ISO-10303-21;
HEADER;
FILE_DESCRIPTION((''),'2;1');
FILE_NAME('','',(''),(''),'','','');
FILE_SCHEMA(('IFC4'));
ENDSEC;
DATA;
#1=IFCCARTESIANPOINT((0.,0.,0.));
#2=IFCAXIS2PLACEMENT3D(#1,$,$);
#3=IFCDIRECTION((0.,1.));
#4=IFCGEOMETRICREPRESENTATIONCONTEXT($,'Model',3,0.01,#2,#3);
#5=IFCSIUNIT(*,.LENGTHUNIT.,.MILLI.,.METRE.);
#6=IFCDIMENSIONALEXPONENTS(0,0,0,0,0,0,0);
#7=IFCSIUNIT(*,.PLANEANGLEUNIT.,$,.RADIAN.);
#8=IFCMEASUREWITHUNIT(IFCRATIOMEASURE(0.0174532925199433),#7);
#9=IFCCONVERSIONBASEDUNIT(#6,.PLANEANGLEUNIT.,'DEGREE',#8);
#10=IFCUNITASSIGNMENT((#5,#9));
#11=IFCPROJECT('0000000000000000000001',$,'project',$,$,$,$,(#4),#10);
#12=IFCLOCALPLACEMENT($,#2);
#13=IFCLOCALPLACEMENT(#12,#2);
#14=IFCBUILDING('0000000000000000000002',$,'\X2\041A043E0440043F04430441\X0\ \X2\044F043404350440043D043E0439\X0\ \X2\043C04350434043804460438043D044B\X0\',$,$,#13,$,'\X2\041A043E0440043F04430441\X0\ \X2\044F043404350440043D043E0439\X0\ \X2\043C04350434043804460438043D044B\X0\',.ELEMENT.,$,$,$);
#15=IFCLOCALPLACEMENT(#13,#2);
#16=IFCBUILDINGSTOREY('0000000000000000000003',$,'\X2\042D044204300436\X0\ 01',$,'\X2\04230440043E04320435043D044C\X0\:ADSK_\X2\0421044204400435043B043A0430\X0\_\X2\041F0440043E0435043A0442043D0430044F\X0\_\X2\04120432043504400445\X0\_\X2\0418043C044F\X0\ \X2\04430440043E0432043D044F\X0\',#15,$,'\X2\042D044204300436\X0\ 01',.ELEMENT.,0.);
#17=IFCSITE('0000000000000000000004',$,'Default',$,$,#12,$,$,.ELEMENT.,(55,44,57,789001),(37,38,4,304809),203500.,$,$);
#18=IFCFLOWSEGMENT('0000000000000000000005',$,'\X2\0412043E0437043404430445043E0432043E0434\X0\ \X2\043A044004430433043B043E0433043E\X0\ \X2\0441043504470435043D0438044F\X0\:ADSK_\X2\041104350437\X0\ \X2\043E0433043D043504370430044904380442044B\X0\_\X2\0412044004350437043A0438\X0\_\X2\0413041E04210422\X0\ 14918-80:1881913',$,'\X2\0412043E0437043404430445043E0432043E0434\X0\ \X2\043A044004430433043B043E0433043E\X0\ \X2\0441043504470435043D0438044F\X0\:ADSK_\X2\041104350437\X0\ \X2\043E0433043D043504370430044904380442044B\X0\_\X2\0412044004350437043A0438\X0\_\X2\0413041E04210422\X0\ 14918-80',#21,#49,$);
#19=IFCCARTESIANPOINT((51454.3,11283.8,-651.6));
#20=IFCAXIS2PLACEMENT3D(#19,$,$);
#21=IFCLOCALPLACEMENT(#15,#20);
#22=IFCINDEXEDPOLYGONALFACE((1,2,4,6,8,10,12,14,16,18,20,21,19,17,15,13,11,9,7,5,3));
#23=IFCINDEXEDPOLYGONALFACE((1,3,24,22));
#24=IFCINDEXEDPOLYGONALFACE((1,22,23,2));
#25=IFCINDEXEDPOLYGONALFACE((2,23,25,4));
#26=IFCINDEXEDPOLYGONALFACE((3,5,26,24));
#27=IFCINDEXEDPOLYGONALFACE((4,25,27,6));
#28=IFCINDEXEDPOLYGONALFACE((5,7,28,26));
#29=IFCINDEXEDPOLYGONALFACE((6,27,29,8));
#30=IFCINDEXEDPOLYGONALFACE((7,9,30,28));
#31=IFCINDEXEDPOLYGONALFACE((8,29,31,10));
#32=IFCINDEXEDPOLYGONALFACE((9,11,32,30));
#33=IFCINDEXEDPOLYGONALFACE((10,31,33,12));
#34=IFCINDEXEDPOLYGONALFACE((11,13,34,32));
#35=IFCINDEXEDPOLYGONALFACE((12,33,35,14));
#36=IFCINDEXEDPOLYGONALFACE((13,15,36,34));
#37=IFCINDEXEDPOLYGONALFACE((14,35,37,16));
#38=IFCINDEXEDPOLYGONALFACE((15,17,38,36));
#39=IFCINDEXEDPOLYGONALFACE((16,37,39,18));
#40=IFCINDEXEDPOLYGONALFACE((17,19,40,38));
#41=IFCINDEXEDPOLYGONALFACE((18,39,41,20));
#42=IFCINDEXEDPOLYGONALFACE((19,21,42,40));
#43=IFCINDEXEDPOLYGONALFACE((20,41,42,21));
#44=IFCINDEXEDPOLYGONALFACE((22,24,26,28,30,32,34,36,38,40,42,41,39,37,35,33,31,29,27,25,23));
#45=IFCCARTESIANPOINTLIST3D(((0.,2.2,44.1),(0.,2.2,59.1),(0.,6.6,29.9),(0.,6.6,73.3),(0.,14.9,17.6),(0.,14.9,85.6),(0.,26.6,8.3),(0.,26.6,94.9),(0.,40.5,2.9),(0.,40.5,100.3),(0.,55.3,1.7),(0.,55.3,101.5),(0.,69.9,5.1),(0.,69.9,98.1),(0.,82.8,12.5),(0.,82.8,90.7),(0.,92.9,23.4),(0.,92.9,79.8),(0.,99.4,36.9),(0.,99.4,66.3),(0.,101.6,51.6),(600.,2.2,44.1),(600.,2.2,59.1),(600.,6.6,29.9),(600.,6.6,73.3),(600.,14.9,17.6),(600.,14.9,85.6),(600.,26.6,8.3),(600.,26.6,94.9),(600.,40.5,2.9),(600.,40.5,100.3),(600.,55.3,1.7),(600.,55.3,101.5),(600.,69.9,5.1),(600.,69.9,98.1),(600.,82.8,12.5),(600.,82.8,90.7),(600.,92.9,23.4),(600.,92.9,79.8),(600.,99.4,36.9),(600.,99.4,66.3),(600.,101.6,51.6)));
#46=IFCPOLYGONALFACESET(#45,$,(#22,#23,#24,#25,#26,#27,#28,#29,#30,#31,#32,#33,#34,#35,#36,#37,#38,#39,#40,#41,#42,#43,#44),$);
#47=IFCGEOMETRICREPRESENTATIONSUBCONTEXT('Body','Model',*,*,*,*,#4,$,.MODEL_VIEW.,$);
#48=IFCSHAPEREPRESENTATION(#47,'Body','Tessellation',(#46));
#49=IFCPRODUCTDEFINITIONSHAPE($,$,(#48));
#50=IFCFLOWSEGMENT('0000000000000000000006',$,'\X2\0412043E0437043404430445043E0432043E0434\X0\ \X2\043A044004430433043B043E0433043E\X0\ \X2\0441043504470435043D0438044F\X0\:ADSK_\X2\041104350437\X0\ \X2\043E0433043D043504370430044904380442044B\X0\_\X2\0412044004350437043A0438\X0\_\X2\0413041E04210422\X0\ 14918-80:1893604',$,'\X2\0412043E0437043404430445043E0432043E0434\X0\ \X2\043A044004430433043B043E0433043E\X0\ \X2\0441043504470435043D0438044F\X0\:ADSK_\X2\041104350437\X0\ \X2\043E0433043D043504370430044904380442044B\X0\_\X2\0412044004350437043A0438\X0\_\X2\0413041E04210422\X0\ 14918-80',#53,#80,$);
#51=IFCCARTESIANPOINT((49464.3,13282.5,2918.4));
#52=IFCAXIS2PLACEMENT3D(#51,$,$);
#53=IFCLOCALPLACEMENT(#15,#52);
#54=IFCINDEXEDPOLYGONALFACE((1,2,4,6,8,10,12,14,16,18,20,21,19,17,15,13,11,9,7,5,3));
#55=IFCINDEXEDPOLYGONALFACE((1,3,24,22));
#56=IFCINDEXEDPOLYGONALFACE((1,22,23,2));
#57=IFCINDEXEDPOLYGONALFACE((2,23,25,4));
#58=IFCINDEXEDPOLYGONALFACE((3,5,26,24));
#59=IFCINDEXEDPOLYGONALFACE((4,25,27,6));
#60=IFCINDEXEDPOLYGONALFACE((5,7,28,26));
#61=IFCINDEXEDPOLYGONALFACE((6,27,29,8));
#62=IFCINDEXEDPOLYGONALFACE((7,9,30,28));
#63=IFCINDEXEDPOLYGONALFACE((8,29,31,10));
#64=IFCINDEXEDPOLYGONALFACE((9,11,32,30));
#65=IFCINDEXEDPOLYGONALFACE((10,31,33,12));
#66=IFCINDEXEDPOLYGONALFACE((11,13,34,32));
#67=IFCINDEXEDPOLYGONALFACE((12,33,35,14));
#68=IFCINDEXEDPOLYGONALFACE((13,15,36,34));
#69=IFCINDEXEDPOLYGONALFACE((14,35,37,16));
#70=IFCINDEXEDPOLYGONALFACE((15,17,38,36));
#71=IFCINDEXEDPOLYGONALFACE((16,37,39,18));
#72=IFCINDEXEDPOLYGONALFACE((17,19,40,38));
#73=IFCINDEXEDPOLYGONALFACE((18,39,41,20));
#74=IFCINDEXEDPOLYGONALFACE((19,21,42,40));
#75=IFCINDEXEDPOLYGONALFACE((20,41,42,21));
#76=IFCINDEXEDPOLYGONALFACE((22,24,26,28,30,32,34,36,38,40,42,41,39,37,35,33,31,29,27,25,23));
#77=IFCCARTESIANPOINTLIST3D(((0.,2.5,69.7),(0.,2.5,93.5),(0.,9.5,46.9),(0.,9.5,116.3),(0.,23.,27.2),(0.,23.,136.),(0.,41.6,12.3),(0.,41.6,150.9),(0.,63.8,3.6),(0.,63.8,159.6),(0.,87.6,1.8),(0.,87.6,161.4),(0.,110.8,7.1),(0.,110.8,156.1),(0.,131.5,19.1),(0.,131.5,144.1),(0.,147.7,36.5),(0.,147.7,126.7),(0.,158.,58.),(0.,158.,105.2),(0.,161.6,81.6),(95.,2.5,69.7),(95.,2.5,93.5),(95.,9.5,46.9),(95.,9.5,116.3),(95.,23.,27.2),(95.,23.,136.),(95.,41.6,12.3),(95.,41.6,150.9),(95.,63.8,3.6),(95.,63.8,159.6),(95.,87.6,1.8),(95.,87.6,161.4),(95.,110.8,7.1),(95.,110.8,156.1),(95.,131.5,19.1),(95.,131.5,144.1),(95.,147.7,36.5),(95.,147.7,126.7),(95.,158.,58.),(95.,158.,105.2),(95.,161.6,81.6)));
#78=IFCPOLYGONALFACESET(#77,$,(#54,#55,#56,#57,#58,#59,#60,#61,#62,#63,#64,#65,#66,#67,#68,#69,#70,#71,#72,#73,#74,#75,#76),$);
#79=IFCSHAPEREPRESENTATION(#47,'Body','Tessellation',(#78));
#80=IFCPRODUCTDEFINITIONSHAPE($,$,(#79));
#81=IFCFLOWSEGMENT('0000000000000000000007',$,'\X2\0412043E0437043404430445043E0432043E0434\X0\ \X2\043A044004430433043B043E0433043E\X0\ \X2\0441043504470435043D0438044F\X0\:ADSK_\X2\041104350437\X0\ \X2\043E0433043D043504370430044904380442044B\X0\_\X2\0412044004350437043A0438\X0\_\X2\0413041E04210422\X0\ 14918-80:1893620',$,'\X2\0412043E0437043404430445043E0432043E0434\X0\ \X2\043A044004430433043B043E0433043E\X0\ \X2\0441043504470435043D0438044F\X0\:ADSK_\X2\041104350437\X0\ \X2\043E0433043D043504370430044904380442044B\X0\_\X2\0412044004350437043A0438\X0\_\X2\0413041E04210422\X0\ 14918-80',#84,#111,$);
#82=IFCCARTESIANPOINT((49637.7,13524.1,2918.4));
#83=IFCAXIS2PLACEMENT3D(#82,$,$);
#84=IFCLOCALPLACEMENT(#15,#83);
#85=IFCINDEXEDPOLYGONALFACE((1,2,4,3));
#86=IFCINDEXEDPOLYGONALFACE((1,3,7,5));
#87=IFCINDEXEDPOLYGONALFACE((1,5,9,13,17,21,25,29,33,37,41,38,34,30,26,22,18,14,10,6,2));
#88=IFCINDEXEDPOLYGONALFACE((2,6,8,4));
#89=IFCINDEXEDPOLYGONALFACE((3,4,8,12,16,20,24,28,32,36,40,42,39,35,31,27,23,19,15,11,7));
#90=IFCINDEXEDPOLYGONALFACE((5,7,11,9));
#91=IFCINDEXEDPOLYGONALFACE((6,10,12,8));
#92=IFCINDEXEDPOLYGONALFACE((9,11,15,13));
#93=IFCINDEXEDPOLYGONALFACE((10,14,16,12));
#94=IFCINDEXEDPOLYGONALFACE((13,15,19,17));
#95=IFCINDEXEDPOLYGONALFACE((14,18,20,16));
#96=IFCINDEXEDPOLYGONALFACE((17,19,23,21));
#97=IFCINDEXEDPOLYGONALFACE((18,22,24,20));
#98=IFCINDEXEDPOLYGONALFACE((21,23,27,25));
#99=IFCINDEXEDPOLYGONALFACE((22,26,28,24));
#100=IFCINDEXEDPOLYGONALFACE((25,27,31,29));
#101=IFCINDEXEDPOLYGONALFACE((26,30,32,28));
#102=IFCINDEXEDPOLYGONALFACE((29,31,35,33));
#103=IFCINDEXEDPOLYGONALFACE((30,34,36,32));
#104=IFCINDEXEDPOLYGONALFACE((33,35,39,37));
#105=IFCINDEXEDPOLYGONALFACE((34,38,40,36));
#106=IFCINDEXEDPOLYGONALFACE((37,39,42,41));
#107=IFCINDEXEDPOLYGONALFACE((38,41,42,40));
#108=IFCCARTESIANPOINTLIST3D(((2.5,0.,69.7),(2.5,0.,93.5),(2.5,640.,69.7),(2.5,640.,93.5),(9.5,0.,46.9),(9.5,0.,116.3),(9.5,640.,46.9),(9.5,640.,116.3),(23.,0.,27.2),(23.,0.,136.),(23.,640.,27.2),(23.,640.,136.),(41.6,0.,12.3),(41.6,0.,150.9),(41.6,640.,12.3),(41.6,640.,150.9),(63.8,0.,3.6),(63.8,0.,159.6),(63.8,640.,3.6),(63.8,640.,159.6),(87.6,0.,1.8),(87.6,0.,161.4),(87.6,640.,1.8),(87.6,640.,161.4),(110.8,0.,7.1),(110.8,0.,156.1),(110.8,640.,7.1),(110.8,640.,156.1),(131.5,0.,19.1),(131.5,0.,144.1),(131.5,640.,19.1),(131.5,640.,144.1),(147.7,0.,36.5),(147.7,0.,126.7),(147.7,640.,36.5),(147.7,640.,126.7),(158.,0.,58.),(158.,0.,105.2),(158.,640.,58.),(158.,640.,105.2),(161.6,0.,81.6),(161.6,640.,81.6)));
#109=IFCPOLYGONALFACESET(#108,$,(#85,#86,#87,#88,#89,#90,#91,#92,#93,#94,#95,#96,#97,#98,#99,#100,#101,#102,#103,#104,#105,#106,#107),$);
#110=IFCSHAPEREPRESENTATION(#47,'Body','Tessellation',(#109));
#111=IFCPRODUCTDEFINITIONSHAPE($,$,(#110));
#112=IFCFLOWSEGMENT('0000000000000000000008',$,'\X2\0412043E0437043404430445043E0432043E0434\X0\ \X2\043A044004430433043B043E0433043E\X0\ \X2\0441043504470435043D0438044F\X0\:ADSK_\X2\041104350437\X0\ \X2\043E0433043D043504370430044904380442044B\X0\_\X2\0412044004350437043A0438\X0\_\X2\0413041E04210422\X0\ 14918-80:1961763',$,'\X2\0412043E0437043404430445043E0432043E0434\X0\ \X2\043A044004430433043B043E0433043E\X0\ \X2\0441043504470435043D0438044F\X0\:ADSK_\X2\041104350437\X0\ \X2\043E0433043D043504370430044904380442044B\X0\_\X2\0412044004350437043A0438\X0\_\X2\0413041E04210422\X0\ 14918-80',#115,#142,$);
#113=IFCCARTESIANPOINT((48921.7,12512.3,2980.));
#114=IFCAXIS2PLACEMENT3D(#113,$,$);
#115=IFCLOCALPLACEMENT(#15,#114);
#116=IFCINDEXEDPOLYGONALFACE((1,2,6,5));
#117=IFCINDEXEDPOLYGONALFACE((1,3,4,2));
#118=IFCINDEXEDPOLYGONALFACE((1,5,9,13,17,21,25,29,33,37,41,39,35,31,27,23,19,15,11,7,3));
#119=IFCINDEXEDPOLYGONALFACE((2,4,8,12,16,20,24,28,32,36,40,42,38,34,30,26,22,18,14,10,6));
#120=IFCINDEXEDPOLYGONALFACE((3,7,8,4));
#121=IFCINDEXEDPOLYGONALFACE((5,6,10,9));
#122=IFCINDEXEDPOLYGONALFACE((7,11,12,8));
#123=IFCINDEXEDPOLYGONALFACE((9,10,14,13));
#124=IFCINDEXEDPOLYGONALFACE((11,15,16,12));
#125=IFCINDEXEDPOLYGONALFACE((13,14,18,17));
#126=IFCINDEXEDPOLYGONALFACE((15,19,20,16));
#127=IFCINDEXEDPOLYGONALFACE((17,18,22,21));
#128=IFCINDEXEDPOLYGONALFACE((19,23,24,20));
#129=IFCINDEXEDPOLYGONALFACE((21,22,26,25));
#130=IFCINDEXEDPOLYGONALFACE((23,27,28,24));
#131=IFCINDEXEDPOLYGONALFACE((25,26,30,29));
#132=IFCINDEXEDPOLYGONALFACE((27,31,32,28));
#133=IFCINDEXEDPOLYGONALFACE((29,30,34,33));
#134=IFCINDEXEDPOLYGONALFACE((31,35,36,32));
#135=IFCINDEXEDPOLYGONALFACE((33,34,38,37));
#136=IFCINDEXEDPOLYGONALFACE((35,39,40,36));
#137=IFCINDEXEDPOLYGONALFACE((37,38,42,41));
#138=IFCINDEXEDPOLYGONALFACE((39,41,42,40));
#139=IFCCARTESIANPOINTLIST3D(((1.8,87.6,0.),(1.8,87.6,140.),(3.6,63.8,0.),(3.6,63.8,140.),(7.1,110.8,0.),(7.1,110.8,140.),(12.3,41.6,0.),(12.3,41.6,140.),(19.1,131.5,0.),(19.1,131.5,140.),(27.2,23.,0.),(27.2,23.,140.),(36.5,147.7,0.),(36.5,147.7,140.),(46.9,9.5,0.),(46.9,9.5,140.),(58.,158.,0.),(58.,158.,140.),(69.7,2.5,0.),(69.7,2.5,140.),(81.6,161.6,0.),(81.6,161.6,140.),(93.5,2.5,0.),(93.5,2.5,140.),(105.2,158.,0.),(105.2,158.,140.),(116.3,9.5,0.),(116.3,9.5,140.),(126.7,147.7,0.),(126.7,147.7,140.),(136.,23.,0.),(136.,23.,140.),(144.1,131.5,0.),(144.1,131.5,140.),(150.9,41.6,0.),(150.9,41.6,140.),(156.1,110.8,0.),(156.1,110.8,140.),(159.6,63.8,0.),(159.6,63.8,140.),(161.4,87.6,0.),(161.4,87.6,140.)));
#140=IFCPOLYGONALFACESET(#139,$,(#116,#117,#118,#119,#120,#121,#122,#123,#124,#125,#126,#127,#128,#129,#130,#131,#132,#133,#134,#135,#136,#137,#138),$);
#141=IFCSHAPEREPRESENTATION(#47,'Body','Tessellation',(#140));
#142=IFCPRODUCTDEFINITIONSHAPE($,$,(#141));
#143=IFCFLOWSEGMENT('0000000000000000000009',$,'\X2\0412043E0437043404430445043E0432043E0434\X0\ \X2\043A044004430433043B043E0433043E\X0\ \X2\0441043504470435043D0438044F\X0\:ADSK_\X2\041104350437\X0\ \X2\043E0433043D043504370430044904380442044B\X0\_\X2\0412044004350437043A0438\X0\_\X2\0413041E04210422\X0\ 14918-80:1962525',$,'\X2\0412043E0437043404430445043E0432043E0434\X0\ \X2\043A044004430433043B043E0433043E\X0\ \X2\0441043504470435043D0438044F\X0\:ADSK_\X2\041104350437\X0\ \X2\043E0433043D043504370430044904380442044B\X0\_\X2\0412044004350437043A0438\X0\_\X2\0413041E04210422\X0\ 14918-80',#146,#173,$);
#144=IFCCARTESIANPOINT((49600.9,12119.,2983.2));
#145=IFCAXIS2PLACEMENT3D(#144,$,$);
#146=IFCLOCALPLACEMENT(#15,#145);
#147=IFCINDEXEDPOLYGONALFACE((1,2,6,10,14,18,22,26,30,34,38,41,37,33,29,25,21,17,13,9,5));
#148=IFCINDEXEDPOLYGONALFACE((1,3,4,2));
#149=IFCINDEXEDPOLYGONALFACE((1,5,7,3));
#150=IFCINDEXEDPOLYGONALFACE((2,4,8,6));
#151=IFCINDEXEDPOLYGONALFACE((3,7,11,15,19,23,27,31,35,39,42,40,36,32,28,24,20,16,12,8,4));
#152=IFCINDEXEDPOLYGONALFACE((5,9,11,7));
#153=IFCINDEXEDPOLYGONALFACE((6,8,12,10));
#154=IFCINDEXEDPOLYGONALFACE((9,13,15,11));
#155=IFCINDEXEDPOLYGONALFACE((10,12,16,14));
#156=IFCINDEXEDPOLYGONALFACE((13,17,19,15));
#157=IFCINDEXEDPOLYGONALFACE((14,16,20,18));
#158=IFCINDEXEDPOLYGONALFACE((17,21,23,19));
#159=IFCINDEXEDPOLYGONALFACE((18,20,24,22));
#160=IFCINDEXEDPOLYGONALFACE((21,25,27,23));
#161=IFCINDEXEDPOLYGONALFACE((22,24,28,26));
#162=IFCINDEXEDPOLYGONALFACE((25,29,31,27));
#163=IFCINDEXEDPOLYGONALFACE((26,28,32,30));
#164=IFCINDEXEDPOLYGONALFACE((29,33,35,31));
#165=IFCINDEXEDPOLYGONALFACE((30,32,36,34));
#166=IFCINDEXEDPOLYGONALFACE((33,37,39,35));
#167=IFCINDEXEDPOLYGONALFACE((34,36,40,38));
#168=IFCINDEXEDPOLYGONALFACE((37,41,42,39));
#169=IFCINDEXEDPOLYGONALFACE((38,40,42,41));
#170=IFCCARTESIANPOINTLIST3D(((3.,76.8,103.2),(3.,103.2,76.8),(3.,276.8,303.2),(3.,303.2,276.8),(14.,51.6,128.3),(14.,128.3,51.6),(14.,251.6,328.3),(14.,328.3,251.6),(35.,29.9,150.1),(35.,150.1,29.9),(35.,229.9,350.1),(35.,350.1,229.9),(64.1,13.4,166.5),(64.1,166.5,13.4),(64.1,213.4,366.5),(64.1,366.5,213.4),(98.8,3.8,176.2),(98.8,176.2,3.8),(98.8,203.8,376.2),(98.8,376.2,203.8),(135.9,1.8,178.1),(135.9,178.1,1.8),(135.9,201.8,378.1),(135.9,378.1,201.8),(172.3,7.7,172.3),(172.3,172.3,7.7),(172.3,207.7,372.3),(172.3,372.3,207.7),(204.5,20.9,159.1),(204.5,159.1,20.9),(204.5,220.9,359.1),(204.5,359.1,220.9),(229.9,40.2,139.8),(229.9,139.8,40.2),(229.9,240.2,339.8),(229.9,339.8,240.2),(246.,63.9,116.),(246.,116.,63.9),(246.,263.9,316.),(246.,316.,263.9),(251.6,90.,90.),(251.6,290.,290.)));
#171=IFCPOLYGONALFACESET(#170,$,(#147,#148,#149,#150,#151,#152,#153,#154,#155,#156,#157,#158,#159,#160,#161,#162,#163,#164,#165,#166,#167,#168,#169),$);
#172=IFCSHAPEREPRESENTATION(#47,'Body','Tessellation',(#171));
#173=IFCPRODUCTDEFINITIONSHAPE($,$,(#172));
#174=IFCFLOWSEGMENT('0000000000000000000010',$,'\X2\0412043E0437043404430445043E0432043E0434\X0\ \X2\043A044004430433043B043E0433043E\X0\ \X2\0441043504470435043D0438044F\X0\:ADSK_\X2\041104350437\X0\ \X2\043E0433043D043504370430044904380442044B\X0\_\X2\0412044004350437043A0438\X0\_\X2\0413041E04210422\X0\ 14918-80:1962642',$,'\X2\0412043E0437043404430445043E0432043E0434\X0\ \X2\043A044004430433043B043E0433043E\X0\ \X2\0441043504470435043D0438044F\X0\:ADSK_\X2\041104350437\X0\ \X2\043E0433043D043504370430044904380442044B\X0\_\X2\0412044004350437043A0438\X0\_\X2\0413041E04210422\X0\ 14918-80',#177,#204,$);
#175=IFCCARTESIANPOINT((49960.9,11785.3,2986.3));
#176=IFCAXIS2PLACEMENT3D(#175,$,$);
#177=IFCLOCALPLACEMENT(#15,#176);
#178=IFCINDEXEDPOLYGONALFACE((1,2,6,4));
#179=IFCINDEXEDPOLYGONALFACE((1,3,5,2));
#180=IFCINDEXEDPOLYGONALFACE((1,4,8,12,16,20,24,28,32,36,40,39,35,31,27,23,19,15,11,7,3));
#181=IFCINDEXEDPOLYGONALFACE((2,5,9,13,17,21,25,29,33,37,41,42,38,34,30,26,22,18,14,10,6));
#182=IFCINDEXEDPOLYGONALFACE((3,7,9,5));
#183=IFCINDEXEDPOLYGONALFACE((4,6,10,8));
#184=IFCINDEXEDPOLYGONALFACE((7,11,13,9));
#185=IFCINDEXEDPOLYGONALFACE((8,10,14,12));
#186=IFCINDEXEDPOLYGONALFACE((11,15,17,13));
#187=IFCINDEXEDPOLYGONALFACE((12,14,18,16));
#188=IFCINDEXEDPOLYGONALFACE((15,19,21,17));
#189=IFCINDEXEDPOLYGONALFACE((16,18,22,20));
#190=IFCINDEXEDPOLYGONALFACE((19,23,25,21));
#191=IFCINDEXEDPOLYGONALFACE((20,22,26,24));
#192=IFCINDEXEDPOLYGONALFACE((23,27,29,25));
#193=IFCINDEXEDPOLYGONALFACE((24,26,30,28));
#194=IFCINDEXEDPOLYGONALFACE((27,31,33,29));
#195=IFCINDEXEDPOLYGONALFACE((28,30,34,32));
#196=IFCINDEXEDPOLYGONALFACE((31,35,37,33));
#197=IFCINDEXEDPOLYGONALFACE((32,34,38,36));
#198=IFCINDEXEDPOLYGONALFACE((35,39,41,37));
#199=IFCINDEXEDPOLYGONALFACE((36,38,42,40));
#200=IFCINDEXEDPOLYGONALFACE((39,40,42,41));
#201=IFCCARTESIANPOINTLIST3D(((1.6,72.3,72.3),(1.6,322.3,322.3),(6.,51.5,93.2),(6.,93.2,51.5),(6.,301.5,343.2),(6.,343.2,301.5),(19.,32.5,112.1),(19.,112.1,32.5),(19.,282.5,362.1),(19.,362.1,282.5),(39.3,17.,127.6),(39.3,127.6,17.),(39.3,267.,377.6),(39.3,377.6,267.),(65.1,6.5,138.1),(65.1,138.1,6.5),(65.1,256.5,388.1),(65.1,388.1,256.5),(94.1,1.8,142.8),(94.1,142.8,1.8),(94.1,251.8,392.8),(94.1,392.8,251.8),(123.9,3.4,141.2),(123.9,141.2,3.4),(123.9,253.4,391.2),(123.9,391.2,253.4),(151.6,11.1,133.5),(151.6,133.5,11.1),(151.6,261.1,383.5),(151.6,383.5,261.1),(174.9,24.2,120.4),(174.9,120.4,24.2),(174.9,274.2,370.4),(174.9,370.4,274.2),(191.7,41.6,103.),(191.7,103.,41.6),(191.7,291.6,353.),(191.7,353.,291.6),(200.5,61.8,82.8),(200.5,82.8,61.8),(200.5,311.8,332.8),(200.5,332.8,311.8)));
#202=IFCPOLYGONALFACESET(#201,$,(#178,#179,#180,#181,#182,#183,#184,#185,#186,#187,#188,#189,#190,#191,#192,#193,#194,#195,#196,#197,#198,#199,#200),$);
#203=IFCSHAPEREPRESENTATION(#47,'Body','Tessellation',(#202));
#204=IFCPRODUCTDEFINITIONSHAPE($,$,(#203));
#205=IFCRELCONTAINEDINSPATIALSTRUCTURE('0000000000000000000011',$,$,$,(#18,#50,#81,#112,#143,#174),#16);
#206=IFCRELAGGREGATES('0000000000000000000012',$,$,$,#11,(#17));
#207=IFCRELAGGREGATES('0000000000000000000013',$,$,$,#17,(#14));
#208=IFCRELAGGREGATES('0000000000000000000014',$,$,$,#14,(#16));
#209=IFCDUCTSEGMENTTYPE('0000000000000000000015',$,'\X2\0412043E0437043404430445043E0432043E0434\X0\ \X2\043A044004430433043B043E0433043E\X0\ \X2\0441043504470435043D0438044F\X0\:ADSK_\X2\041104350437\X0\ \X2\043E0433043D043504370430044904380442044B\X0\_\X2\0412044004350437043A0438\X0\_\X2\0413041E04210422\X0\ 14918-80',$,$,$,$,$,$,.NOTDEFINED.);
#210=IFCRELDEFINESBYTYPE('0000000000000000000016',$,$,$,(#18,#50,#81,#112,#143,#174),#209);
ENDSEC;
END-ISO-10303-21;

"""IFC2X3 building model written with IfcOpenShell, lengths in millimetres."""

from ifc_helpers import new_model, entity, si_unit, converted_unit, direction, frame, origin, origin_2d_with_axis, place, context, subcontext, project, spatial, circle, extrude, type_object, element, save


model = new_model("IFC2X3")

# Units and contexts
model_context = context("Model", 3, precision=0.01, world=origin(), true_north=direction((0.0, 1.0)))
body_context = subcontext(model_context, "Body", "Model", "MODEL_VIEW")
ifc_project = project(units=[si_unit("LENGTHUNIT", "METRE", prefix="MILLI"), converted_unit("PLANEANGLEUNIT", "DEGREE", entity("IfcRatioMeasure", 0.0174532925199433), si_unit("PLANEANGLEUNIT", "RADIAN"), dimensions=[0, 0, 0, 0, 0, 0, 0])], contexts=[model_context])

# Site, building, storey
site_placement = place(None, origin())
site = spatial("IfcSite", under=ifc_project, at=site_placement, Name="Default", CompositionType="ELEMENT", RefLatitude=(55, 44, 57, 789001), RefLongitude=(37, 38, 4, 304809), RefElevation=203500.0)
building_placement = place(site_placement, origin())
building = spatial("IfcBuilding", under=site, at=building_placement, Name="Корпус ядерной медицины", LongName="Корпус ядерной медицины", CompositionType="ELEMENT")
storey_placement = place(building_placement, origin())
storey = spatial("IfcBuildingStorey", under=building, at=storey_placement, Name="Этаж 01", ObjectType="Уровень:ADSK_Стрелка_Проектная_Вверх_Имя уровня", LongName="Этаж 01", CompositionType="ELEMENT", Elevation=0.0)

# Flow segments
duct_segment_type_1 = type_object("IfcDuctSegmentType", Name="Воздуховод круглого сечения:ADSK_Без огнезащиты_Врезки_ГОСТ 14918-80", PredefinedType="NOTDEFINED")
flow_segment_1_placement = place(storey_placement, frame((51454.3, 11283.8, -651.6)))
element("IfcFlowSegment", 1, at=flow_segment_1_placement, inside=storey, type_object=duct_segment_type_1, Name="Воздуховод круглого сечения:ADSK_Без огнезащиты_Врезки_ГОСТ 14918-80:1881913", ObjectType="Воздуховод круглого сечения:ADSK_Без огнезащиты_Врезки_ГОСТ 14918-80", context=body_context, shape_type="SweptSolid", body=[
    extrude(circle(Radius=50.0, at=origin_2d_with_axis()), frame((0.0, 51.6, 51.6), z_axis=(1.0, 0.0, 0.0), x_axis=(0.0, 1.0, 0.0)), (0.0, 0.0, 1.0), 600.0),
])
flow_segment_2_placement = place(storey_placement, frame((49464.3, 13282.5, 2918.4)))
element("IfcFlowSegment", 2, at=flow_segment_2_placement, inside=storey, type_object=duct_segment_type_1, Name="Воздуховод круглого сечения:ADSK_Без огнезащиты_Врезки_ГОСТ 14918-80:1893604", ObjectType="Воздуховод круглого сечения:ADSK_Без огнезащиты_Врезки_ГОСТ 14918-80", context=body_context, shape_type="SweptSolid", body=[
    extrude(circle(Radius=80.0, at=origin_2d_with_axis()), frame((0.0, 81.6, 81.6), z_axis=(1.0, 0.0, 0.0), x_axis=(0.0, 1.0, 0.0)), (0.0, 0.0, 1.0), 95.0),
])
flow_segment_3_placement = place(storey_placement, frame((49637.7, 13524.1, 2918.4)))
element("IfcFlowSegment", 3, at=flow_segment_3_placement, inside=storey, type_object=duct_segment_type_1, Name="Воздуховод круглого сечения:ADSK_Без огнезащиты_Врезки_ГОСТ 14918-80:1893620", ObjectType="Воздуховод круглого сечения:ADSK_Без огнезащиты_Врезки_ГОСТ 14918-80", context=body_context, shape_type="SweptSolid", body=[
    extrude(circle(Radius=80.0, at=origin_2d_with_axis()), frame((81.6, 0.0, 81.6), z_axis=(0.0, 1.0, 0.0), x_axis=(1.0, 0.0, 0.0)), (0.0, 0.0, 1.0), 640.0),
])
flow_segment_4_placement = place(storey_placement, frame((48921.7, 12512.3, 2980.0)))
element("IfcFlowSegment", 4, at=flow_segment_4_placement, inside=storey, type_object=duct_segment_type_1, Name="Воздуховод круглого сечения:ADSK_Без огнезащиты_Врезки_ГОСТ 14918-80:1961763", ObjectType="Воздуховод круглого сечения:ADSK_Без огнезащиты_Врезки_ГОСТ 14918-80", context=body_context, shape_type="SweptSolid", body=[
    extrude(circle(Radius=80.0, at=origin_2d_with_axis()), frame((81.6, 81.6, 0.0), z_axis=(0.0, 0.0, 1.0), x_axis=(0.0, 1.0, 0.0)), (0.0, 0.0, 1.0), 140.0),
])
flow_segment_5_placement = place(storey_placement, frame((49600.9, 12119.0, 2983.2)))
element("IfcFlowSegment", 5, at=flow_segment_5_placement, inside=storey, type_object=duct_segment_type_1, Name="Воздуховод круглого сечения:ADSK_Без огнезащиты_Врезки_ГОСТ 14918-80:1962525", ObjectType="Воздуховод круглого сечения:ADSK_Без огнезащиты_Врезки_ГОСТ 14918-80", context=body_context, shape_type="SweptSolid", body=[
    extrude(circle(Radius=125.0, at=origin_2d_with_axis()), frame((126.6, 90.0, 90.0), z_axis=(0.0, 0.707107, 0.707107), x_axis=(1.0, 0.0, 0.0)), (0.0, 0.0, 1.0), 282.8),
])
flow_segment_6_placement = place(storey_placement, frame((49960.9, 11785.3, 2986.3)))
element("IfcFlowSegment", 6, at=flow_segment_6_placement, inside=storey, type_object=duct_segment_type_1, Name="Воздуховод круглого сечения:ADSK_Без огнезащиты_Врезки_ГОСТ 14918-80:1962642", ObjectType="Воздуховод круглого сечения:ADSK_Без огнезащиты_Врезки_ГОСТ 14918-80", context=body_context, shape_type="SweptSolid", body=[
    extrude(circle(Radius=100.0, at=origin_2d_with_axis()), frame((101.6, 72.3, 72.3), z_axis=(0.0, 0.707107, 0.707107), x_axis=(-1.0, 0.0, 0.0)), (0.0, 0.0, 1.0), 353.6),
])

save(model, "model.ifc")
